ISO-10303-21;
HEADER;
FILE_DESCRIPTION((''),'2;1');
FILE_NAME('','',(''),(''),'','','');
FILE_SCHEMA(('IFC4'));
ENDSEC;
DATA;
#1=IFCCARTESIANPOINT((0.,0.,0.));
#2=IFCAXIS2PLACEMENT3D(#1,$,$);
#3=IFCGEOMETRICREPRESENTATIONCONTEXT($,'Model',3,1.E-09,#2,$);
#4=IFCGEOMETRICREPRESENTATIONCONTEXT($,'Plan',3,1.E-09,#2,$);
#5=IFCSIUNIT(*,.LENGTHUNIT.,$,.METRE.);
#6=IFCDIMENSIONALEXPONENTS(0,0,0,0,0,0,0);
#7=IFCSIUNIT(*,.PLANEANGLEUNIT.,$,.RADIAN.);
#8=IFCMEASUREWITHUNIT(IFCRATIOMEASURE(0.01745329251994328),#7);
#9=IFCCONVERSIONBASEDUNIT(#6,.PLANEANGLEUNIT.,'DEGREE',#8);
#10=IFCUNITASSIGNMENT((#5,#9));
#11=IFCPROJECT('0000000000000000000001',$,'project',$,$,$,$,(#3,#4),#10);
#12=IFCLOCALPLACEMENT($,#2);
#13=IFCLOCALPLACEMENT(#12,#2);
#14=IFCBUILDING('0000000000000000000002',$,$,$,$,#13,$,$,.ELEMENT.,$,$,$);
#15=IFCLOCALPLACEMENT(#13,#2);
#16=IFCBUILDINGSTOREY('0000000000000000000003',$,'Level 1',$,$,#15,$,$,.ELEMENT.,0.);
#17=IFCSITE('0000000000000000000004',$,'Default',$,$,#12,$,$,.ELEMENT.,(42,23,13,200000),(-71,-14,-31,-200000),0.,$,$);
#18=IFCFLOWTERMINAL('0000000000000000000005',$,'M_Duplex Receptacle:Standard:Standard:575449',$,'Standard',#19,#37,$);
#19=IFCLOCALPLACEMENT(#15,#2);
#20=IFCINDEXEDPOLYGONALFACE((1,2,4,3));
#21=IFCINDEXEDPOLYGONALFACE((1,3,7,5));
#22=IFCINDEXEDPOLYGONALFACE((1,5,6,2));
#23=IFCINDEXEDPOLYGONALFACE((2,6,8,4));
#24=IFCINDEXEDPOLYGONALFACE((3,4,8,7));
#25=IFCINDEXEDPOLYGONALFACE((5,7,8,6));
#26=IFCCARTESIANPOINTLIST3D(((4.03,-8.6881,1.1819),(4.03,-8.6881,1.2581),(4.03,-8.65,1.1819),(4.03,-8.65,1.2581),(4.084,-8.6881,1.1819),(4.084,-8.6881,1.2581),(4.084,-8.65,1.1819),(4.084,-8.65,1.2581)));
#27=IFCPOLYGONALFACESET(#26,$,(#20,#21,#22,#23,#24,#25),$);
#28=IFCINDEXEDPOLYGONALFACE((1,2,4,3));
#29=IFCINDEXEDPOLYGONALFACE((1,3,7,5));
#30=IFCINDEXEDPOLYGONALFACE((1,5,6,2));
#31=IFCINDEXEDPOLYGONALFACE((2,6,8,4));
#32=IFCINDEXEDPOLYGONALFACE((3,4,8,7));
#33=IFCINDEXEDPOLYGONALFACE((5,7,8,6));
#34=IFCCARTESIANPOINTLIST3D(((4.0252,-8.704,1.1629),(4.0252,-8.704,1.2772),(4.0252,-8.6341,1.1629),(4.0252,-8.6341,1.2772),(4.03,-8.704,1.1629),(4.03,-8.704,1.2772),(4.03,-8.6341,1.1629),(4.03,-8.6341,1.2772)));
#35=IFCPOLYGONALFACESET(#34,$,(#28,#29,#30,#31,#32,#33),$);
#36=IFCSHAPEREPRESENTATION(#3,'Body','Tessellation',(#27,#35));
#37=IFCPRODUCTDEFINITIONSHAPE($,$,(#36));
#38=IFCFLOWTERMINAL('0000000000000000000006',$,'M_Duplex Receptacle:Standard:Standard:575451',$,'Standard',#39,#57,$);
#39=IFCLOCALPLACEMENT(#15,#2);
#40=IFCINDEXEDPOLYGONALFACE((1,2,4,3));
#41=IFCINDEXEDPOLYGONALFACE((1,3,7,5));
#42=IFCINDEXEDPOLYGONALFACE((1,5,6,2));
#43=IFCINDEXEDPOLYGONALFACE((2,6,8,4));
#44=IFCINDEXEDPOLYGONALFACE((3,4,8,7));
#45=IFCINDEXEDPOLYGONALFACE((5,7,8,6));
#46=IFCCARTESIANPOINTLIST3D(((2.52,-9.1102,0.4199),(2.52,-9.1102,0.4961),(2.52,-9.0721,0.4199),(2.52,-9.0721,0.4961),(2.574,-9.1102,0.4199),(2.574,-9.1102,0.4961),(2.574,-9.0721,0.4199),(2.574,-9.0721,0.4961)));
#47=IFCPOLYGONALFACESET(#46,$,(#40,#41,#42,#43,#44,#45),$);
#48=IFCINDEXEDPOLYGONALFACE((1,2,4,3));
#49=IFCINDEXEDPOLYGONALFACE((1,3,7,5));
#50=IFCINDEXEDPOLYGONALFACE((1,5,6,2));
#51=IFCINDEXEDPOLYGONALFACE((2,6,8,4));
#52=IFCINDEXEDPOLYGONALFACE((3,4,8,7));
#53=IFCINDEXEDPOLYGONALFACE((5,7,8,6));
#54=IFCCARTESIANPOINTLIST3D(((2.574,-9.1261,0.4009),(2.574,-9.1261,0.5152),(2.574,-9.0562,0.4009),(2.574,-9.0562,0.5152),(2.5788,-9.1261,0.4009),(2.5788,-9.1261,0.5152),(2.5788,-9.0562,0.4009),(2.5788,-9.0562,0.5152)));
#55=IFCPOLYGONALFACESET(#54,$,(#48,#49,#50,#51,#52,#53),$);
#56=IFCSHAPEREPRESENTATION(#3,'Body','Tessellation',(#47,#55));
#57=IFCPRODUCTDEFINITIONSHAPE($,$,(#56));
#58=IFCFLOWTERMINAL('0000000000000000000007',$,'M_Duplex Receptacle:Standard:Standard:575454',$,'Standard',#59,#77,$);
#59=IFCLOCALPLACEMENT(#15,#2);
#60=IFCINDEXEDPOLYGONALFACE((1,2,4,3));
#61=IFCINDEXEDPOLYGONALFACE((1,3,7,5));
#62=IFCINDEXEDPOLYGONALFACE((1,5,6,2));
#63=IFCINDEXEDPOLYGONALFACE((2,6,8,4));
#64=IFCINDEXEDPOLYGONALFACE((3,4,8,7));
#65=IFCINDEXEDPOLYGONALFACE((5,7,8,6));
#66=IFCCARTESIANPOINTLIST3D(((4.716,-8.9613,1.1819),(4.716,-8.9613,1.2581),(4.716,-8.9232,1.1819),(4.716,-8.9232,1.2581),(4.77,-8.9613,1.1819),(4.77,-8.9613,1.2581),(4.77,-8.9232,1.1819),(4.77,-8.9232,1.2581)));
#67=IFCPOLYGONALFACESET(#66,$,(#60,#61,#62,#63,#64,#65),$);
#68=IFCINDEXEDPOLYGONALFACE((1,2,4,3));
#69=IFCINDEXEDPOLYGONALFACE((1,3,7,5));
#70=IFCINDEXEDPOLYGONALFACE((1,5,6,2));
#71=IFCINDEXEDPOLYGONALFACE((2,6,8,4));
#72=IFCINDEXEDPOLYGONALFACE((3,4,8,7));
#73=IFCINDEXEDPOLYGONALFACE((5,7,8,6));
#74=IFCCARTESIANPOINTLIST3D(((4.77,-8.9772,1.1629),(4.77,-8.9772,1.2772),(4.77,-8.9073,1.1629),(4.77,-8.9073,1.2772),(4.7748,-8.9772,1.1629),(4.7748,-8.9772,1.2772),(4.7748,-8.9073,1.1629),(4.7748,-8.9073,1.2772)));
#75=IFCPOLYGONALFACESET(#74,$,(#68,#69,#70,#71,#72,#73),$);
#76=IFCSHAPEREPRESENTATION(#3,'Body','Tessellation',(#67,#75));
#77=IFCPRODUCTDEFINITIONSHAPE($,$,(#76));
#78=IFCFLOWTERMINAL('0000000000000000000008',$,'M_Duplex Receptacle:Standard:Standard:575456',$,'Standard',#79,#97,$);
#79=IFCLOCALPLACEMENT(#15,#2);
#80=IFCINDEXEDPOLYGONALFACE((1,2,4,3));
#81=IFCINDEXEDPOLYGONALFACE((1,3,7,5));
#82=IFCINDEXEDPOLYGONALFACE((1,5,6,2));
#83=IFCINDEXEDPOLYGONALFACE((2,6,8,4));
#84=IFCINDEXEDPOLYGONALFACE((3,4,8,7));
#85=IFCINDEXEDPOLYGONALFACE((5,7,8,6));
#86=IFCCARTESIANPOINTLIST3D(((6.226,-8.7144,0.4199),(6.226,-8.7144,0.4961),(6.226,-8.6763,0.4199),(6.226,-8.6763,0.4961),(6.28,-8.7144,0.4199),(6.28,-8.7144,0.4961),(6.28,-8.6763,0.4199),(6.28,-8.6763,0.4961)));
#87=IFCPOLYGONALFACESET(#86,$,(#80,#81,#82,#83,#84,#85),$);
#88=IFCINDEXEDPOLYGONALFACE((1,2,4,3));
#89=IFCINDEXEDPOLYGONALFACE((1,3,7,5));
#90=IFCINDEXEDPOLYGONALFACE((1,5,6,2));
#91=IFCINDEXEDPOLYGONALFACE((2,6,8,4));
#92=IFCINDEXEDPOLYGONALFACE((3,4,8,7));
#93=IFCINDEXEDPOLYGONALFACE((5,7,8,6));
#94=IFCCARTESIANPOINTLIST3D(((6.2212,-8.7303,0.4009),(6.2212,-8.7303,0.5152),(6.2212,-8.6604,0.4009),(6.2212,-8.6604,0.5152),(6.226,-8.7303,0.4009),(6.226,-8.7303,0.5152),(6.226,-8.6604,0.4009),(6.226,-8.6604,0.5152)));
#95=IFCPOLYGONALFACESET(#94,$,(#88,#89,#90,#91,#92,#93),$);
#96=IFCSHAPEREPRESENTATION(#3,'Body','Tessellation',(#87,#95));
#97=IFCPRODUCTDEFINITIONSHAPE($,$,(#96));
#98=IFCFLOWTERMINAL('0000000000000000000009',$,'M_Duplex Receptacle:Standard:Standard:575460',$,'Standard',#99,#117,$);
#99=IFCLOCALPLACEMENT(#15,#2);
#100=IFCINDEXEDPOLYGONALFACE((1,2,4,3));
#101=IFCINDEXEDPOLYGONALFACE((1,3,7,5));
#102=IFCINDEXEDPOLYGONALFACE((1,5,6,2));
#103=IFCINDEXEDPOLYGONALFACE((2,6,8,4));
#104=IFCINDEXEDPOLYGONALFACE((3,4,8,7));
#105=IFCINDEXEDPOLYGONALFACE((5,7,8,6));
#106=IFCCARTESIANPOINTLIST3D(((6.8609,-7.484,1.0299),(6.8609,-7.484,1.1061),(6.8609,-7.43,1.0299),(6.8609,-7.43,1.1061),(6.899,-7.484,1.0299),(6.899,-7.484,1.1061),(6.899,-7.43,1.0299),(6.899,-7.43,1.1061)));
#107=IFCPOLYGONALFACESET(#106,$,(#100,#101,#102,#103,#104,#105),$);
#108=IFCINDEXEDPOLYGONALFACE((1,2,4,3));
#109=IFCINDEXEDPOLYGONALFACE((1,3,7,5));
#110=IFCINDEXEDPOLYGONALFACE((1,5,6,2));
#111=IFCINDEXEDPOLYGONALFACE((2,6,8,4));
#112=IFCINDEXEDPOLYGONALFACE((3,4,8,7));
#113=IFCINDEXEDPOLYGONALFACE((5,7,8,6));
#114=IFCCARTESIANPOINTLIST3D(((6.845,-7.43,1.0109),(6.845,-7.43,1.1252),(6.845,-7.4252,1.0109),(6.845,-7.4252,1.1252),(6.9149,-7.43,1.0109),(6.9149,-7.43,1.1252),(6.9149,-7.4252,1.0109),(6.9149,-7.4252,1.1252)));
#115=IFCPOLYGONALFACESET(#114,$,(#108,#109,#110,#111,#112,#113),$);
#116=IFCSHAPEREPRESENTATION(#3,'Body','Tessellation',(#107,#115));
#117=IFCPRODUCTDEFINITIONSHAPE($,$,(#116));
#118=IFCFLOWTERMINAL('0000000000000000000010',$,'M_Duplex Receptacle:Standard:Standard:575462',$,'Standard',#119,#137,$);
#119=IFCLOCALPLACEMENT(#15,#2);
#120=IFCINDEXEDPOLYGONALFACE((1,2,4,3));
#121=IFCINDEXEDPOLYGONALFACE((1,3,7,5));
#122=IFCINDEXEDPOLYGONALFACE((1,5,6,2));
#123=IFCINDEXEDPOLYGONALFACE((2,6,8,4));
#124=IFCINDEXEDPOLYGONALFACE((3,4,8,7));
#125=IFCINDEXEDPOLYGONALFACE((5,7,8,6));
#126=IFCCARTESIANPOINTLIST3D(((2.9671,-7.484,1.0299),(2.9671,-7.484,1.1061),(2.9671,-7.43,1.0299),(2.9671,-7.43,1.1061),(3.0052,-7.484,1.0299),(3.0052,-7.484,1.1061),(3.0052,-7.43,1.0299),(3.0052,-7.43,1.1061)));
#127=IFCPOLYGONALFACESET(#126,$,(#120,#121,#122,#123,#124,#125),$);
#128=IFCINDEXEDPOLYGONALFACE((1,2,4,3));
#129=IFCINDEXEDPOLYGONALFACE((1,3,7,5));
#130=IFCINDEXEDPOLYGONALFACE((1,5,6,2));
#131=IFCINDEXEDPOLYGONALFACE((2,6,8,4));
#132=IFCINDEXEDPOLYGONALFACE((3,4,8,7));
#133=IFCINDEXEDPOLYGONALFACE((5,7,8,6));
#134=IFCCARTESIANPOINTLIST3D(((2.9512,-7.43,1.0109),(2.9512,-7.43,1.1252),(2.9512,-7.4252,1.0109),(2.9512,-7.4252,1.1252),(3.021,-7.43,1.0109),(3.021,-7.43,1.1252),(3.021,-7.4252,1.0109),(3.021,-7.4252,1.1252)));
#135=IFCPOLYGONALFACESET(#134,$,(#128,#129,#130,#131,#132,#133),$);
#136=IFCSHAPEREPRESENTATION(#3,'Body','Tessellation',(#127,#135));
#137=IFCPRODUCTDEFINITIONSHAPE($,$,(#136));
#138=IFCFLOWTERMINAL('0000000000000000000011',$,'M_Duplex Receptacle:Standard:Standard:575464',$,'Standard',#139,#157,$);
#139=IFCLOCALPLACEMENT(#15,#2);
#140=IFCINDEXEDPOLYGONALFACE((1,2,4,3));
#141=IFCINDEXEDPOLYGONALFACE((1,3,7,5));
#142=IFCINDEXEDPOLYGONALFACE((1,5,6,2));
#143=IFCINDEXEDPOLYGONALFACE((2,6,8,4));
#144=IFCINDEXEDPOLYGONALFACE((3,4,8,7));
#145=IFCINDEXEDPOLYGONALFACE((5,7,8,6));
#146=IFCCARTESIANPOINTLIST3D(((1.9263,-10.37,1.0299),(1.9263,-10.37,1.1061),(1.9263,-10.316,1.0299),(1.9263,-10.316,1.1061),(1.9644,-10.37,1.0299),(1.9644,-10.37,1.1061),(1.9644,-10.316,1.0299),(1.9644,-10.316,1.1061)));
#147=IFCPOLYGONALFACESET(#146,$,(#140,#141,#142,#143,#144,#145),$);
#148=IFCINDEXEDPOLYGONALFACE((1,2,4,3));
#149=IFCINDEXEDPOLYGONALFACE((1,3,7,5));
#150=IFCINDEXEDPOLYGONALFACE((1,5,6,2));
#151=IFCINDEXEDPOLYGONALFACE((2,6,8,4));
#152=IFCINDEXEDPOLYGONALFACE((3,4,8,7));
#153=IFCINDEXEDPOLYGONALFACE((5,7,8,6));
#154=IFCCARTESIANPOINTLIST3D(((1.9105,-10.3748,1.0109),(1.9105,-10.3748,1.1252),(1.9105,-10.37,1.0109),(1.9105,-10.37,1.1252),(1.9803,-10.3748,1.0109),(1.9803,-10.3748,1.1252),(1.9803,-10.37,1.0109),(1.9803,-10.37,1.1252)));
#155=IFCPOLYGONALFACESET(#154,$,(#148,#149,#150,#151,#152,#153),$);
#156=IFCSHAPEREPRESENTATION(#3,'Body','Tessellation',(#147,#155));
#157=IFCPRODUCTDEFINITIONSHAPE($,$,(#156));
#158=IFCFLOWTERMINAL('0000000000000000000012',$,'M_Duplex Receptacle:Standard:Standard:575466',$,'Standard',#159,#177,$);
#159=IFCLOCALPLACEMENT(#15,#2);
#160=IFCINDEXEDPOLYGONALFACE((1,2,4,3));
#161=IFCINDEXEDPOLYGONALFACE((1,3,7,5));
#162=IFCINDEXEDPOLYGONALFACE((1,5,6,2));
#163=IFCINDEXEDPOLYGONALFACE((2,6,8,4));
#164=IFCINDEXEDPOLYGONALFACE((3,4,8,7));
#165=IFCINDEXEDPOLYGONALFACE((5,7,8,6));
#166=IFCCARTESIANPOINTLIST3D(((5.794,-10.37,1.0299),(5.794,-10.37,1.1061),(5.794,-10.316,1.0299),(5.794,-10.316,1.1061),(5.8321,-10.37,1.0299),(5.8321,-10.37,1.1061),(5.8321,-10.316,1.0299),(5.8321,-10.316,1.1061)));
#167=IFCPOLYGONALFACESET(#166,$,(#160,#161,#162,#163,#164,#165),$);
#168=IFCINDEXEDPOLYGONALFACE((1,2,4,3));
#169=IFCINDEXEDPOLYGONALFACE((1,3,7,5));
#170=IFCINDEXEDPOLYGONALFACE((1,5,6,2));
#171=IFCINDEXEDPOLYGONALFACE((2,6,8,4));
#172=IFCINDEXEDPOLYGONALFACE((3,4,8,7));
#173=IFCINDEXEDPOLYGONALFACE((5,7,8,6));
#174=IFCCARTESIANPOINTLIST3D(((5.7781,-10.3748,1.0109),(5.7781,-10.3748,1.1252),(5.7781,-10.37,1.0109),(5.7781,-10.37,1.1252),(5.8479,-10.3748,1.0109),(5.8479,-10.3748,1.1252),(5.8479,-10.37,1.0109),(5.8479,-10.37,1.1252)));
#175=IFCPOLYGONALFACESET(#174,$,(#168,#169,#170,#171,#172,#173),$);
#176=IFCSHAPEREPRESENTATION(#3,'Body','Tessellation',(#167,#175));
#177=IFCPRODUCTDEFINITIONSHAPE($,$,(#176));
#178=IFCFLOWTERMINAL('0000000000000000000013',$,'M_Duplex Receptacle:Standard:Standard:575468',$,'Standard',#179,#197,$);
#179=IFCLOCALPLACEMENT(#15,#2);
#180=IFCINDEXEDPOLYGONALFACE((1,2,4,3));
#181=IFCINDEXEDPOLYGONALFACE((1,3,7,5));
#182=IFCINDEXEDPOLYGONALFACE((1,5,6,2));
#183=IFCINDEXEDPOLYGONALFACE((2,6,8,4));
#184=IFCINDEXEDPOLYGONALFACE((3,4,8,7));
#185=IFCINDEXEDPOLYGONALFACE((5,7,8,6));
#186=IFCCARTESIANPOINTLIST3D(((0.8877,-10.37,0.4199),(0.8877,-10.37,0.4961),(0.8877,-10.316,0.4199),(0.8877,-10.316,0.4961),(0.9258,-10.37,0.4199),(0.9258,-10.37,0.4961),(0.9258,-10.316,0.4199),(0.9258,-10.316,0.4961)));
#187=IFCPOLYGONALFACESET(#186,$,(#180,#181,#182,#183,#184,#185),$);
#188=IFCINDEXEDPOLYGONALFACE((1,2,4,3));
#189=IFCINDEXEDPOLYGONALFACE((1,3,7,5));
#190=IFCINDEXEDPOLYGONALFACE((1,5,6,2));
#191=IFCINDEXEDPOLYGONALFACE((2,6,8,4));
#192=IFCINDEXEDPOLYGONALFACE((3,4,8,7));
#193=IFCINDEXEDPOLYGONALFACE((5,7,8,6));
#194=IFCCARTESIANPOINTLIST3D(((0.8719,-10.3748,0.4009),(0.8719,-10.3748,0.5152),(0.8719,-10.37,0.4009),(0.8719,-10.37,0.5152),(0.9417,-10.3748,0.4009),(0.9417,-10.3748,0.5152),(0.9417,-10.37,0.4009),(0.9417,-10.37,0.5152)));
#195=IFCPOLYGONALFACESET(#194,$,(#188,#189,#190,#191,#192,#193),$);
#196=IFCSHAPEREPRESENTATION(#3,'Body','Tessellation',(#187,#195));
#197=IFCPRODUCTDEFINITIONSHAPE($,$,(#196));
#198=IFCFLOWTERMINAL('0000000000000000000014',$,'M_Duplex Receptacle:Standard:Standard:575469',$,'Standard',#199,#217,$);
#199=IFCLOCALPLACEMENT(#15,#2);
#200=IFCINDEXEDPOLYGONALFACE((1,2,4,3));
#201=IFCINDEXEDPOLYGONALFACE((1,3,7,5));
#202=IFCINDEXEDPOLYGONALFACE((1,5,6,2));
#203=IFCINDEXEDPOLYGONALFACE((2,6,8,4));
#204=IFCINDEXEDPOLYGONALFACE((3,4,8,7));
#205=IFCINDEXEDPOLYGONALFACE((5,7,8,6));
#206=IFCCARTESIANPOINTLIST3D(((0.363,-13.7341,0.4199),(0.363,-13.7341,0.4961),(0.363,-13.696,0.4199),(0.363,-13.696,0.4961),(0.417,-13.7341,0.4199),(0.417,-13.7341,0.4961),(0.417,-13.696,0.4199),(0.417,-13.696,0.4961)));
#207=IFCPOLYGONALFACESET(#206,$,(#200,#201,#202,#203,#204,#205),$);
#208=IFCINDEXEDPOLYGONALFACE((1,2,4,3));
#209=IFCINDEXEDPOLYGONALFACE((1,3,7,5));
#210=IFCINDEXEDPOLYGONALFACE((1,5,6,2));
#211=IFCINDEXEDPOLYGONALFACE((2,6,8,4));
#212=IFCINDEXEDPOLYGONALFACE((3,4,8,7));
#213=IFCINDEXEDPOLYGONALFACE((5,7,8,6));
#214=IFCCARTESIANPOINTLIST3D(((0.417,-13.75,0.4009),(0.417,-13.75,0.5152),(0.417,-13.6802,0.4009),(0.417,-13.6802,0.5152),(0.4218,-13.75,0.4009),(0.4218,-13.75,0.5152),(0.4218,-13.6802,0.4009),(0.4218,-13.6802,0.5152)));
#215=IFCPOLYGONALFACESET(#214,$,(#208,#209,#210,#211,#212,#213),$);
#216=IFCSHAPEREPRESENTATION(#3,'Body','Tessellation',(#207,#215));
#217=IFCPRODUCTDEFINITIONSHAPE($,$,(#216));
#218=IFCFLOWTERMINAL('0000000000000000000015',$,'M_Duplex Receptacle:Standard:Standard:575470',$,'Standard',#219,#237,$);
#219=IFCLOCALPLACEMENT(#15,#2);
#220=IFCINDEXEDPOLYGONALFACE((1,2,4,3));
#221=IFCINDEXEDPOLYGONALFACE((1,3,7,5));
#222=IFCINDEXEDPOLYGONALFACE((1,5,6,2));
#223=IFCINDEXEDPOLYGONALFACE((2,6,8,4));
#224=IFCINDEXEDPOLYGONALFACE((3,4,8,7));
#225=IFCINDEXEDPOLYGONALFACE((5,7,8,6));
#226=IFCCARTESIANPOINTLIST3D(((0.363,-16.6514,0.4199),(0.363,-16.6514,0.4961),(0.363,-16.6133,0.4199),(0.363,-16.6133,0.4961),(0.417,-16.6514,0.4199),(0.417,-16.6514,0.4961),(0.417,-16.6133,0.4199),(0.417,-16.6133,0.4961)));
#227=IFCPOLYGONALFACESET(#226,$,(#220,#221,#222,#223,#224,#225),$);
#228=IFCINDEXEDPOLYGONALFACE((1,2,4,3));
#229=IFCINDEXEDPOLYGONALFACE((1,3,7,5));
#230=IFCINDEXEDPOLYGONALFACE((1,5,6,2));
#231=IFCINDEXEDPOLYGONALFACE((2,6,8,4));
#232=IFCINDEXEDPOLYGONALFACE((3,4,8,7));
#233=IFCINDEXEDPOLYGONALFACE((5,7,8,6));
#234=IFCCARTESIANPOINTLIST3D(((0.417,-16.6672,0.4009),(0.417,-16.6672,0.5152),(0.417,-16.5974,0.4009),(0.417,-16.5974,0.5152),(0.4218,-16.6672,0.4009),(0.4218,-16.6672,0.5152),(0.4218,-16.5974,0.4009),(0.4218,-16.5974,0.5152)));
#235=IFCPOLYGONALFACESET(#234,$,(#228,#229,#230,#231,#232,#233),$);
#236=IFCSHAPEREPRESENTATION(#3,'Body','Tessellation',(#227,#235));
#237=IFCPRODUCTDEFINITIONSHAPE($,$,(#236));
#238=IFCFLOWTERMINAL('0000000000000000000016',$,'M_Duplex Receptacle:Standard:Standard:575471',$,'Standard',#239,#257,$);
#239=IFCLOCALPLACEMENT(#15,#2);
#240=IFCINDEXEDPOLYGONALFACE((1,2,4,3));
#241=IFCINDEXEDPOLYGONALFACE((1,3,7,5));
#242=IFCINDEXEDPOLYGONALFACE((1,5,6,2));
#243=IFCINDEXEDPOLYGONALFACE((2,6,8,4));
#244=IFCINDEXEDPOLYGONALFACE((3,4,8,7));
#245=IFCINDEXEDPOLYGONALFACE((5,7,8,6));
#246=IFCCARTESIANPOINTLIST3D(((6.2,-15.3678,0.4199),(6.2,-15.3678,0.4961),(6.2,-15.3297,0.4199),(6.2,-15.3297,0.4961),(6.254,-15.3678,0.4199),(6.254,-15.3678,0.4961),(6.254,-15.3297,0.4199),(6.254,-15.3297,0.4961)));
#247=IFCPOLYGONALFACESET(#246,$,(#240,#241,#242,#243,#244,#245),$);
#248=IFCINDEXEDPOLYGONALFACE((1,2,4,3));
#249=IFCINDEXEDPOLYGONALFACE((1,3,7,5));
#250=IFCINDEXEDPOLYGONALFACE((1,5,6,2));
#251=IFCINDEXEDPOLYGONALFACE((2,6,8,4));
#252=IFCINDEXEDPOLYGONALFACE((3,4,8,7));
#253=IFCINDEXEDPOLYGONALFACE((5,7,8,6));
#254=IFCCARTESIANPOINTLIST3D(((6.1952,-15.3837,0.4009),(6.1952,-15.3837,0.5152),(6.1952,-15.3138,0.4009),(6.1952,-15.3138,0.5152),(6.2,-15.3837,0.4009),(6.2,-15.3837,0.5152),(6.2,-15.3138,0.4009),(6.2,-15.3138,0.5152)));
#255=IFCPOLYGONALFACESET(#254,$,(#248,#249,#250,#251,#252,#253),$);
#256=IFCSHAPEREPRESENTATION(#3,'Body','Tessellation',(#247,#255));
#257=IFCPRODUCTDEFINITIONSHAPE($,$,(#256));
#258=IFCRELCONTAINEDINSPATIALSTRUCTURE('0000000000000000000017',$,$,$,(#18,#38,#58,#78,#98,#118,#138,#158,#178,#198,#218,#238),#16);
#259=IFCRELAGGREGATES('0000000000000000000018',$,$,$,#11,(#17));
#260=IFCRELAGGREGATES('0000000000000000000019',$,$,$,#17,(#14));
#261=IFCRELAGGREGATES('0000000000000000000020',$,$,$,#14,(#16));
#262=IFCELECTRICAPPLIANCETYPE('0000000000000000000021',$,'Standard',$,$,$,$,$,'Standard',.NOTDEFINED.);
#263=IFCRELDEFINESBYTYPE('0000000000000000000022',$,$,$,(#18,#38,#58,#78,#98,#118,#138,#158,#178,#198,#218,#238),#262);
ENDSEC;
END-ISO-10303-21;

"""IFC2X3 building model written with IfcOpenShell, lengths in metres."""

from ifc_helpers import new_model, entity, si_unit, converted_unit, frame, origin, origin_2d_with_axis, place, context, project, spatial, rectangle, extrude, source, transform, mapped, type_object, type_shapes, element, save


model = new_model("IFC2X3")

# Units and contexts
model_context = context("Model", 3, precision=1e-09, world=origin())
plan_context = context("Plan", 3, precision=1e-09, world=origin())
ifc_project = project(units=[si_unit("LENGTHUNIT", "METRE"), converted_unit("PLANEANGLEUNIT", "DEGREE", entity("IfcRatioMeasure", 0.01745329251994328), si_unit("PLANEANGLEUNIT", "RADIAN"), dimensions=[0, 0, 0, 0, 0, 0, 0])], contexts=[model_context, plan_context])

# Site, building, storey
site_placement = place(None, origin())
site = spatial("IfcSite", under=ifc_project, at=site_placement, Name="Default", CompositionType="ELEMENT", RefLatitude=(42, 23, 13, 200000), RefLongitude=(-71, -14, -31, -200000), RefElevation=0.0)
building_placement = place(site_placement, origin())
building = spatial("IfcBuilding", under=site, at=building_placement, CompositionType="ELEMENT")
storey_placement = place(building_placement, origin())
storey = spatial("IfcBuildingStorey", under=building, at=storey_placement, Name="Level 1", CompositionType="ELEMENT", Elevation=0.0)

# Flow terminals
electric_appliance_type_1 = type_object("IfcElectricApplianceType", Name="Standard", ElementType="Standard", PredefinedType="NOTDEFINED")
shared_shape_1 = source(origin(), model_context, "Body", "SweptSolid", [
    extrude(rectangle(XDim=0.0381, YDim=0.0762, at=origin_2d_with_axis()), frame((0.0, 0.0, -0.054), z_axis=(0.0, 0.0, 1.0), x_axis=(-1.0, 0.0, 0.0)), (0.0, 0.0, 1.0), 0.054),
    extrude(rectangle(XDim=0.0698, YDim=0.1143, at=origin_2d_with_axis()), frame((0.0, 0.0, 0.0), z_axis=(0.0, 0.0, 1.0), x_axis=(-1.0, 0.0, 0.0)), (0.0, 0.0, 1.0), 0.0048),
])
type_shapes(electric_appliance_type_1, [shared_shape_1])
for number, where, z_axis, x_axis, name in (
    (1, (4.03, -8.6691, 1.22), (-1.0, 0.0, 0.0), (0.0, -1.0, 0.0), "M_Duplex Receptacle:Standard:Standard:575449"),
    (2, (2.574, -9.0912, 0.458), (1.0, 0.0, 0.0), (0.0, 1.0, 0.0), "M_Duplex Receptacle:Standard:Standard:575451"),
    (3, (4.77, -8.9422, 1.22), (1.0, 0.0, 0.0), (0.0, 1.0, 0.0), "M_Duplex Receptacle:Standard:Standard:575454"),
    (4, (6.226, -8.6953, 0.458), (-1.0, 0.0, 0.0), (0.0, -1.0, 0.0), "M_Duplex Receptacle:Standard:Standard:575456"),
    (5, (6.88, -7.43, 1.068), (0.0, 1.0, 0.0), (-1.0, 0.0, 0.0), "M_Duplex Receptacle:Standard:Standard:575460"),
    (6, (2.9861, -7.43, 1.068), (0.0, 1.0, 0.0), (-1.0, 0.0, 0.0), "M_Duplex Receptacle:Standard:Standard:575462"),
    (7, (1.9454, -10.37, 1.068), (0.0, -1.0, 0.0), (1.0, 0.0, 0.0), "M_Duplex Receptacle:Standard:Standard:575464"),
    (8, (5.813, -10.37, 1.068), (0.0, -1.0, 0.0), (1.0, 0.0, 0.0), "M_Duplex Receptacle:Standard:Standard:575466"),
    (9, (0.9068, -10.37, 0.458), (0.0, -1.0, 0.0), (1.0, 0.0, 0.0), "M_Duplex Receptacle:Standard:Standard:575468"),
    (10, (0.417, -13.7151, 0.458), (1.0, 0.0, 0.0), (0.0, 1.0, 0.0), "M_Duplex Receptacle:Standard:Standard:575469"),
    (11, (0.417, -16.6323, 0.458), (1.0, 0.0, 0.0), (0.0, 1.0, 0.0), "M_Duplex Receptacle:Standard:Standard:575470"),
    (12, (6.2, -15.3487, 0.458), (-1.0, 0.0, 0.0), (0.0, -1.0, 0.0), "M_Duplex Receptacle:Standard:Standard:575471"),
):
    element("IfcFlowTerminal", number, at=place(storey_placement, frame(where, z_axis=z_axis, x_axis=x_axis)), inside=storey, type_object=electric_appliance_type_1, Name=name, ObjectType="Standard", context=model_context, shape_type="MappedRepresentation", body=[
        mapped(shared_shape_1, transform((0.0, 0.0, 0.0), scale=1.0)),
    ])

save(model, "model.ifc")
